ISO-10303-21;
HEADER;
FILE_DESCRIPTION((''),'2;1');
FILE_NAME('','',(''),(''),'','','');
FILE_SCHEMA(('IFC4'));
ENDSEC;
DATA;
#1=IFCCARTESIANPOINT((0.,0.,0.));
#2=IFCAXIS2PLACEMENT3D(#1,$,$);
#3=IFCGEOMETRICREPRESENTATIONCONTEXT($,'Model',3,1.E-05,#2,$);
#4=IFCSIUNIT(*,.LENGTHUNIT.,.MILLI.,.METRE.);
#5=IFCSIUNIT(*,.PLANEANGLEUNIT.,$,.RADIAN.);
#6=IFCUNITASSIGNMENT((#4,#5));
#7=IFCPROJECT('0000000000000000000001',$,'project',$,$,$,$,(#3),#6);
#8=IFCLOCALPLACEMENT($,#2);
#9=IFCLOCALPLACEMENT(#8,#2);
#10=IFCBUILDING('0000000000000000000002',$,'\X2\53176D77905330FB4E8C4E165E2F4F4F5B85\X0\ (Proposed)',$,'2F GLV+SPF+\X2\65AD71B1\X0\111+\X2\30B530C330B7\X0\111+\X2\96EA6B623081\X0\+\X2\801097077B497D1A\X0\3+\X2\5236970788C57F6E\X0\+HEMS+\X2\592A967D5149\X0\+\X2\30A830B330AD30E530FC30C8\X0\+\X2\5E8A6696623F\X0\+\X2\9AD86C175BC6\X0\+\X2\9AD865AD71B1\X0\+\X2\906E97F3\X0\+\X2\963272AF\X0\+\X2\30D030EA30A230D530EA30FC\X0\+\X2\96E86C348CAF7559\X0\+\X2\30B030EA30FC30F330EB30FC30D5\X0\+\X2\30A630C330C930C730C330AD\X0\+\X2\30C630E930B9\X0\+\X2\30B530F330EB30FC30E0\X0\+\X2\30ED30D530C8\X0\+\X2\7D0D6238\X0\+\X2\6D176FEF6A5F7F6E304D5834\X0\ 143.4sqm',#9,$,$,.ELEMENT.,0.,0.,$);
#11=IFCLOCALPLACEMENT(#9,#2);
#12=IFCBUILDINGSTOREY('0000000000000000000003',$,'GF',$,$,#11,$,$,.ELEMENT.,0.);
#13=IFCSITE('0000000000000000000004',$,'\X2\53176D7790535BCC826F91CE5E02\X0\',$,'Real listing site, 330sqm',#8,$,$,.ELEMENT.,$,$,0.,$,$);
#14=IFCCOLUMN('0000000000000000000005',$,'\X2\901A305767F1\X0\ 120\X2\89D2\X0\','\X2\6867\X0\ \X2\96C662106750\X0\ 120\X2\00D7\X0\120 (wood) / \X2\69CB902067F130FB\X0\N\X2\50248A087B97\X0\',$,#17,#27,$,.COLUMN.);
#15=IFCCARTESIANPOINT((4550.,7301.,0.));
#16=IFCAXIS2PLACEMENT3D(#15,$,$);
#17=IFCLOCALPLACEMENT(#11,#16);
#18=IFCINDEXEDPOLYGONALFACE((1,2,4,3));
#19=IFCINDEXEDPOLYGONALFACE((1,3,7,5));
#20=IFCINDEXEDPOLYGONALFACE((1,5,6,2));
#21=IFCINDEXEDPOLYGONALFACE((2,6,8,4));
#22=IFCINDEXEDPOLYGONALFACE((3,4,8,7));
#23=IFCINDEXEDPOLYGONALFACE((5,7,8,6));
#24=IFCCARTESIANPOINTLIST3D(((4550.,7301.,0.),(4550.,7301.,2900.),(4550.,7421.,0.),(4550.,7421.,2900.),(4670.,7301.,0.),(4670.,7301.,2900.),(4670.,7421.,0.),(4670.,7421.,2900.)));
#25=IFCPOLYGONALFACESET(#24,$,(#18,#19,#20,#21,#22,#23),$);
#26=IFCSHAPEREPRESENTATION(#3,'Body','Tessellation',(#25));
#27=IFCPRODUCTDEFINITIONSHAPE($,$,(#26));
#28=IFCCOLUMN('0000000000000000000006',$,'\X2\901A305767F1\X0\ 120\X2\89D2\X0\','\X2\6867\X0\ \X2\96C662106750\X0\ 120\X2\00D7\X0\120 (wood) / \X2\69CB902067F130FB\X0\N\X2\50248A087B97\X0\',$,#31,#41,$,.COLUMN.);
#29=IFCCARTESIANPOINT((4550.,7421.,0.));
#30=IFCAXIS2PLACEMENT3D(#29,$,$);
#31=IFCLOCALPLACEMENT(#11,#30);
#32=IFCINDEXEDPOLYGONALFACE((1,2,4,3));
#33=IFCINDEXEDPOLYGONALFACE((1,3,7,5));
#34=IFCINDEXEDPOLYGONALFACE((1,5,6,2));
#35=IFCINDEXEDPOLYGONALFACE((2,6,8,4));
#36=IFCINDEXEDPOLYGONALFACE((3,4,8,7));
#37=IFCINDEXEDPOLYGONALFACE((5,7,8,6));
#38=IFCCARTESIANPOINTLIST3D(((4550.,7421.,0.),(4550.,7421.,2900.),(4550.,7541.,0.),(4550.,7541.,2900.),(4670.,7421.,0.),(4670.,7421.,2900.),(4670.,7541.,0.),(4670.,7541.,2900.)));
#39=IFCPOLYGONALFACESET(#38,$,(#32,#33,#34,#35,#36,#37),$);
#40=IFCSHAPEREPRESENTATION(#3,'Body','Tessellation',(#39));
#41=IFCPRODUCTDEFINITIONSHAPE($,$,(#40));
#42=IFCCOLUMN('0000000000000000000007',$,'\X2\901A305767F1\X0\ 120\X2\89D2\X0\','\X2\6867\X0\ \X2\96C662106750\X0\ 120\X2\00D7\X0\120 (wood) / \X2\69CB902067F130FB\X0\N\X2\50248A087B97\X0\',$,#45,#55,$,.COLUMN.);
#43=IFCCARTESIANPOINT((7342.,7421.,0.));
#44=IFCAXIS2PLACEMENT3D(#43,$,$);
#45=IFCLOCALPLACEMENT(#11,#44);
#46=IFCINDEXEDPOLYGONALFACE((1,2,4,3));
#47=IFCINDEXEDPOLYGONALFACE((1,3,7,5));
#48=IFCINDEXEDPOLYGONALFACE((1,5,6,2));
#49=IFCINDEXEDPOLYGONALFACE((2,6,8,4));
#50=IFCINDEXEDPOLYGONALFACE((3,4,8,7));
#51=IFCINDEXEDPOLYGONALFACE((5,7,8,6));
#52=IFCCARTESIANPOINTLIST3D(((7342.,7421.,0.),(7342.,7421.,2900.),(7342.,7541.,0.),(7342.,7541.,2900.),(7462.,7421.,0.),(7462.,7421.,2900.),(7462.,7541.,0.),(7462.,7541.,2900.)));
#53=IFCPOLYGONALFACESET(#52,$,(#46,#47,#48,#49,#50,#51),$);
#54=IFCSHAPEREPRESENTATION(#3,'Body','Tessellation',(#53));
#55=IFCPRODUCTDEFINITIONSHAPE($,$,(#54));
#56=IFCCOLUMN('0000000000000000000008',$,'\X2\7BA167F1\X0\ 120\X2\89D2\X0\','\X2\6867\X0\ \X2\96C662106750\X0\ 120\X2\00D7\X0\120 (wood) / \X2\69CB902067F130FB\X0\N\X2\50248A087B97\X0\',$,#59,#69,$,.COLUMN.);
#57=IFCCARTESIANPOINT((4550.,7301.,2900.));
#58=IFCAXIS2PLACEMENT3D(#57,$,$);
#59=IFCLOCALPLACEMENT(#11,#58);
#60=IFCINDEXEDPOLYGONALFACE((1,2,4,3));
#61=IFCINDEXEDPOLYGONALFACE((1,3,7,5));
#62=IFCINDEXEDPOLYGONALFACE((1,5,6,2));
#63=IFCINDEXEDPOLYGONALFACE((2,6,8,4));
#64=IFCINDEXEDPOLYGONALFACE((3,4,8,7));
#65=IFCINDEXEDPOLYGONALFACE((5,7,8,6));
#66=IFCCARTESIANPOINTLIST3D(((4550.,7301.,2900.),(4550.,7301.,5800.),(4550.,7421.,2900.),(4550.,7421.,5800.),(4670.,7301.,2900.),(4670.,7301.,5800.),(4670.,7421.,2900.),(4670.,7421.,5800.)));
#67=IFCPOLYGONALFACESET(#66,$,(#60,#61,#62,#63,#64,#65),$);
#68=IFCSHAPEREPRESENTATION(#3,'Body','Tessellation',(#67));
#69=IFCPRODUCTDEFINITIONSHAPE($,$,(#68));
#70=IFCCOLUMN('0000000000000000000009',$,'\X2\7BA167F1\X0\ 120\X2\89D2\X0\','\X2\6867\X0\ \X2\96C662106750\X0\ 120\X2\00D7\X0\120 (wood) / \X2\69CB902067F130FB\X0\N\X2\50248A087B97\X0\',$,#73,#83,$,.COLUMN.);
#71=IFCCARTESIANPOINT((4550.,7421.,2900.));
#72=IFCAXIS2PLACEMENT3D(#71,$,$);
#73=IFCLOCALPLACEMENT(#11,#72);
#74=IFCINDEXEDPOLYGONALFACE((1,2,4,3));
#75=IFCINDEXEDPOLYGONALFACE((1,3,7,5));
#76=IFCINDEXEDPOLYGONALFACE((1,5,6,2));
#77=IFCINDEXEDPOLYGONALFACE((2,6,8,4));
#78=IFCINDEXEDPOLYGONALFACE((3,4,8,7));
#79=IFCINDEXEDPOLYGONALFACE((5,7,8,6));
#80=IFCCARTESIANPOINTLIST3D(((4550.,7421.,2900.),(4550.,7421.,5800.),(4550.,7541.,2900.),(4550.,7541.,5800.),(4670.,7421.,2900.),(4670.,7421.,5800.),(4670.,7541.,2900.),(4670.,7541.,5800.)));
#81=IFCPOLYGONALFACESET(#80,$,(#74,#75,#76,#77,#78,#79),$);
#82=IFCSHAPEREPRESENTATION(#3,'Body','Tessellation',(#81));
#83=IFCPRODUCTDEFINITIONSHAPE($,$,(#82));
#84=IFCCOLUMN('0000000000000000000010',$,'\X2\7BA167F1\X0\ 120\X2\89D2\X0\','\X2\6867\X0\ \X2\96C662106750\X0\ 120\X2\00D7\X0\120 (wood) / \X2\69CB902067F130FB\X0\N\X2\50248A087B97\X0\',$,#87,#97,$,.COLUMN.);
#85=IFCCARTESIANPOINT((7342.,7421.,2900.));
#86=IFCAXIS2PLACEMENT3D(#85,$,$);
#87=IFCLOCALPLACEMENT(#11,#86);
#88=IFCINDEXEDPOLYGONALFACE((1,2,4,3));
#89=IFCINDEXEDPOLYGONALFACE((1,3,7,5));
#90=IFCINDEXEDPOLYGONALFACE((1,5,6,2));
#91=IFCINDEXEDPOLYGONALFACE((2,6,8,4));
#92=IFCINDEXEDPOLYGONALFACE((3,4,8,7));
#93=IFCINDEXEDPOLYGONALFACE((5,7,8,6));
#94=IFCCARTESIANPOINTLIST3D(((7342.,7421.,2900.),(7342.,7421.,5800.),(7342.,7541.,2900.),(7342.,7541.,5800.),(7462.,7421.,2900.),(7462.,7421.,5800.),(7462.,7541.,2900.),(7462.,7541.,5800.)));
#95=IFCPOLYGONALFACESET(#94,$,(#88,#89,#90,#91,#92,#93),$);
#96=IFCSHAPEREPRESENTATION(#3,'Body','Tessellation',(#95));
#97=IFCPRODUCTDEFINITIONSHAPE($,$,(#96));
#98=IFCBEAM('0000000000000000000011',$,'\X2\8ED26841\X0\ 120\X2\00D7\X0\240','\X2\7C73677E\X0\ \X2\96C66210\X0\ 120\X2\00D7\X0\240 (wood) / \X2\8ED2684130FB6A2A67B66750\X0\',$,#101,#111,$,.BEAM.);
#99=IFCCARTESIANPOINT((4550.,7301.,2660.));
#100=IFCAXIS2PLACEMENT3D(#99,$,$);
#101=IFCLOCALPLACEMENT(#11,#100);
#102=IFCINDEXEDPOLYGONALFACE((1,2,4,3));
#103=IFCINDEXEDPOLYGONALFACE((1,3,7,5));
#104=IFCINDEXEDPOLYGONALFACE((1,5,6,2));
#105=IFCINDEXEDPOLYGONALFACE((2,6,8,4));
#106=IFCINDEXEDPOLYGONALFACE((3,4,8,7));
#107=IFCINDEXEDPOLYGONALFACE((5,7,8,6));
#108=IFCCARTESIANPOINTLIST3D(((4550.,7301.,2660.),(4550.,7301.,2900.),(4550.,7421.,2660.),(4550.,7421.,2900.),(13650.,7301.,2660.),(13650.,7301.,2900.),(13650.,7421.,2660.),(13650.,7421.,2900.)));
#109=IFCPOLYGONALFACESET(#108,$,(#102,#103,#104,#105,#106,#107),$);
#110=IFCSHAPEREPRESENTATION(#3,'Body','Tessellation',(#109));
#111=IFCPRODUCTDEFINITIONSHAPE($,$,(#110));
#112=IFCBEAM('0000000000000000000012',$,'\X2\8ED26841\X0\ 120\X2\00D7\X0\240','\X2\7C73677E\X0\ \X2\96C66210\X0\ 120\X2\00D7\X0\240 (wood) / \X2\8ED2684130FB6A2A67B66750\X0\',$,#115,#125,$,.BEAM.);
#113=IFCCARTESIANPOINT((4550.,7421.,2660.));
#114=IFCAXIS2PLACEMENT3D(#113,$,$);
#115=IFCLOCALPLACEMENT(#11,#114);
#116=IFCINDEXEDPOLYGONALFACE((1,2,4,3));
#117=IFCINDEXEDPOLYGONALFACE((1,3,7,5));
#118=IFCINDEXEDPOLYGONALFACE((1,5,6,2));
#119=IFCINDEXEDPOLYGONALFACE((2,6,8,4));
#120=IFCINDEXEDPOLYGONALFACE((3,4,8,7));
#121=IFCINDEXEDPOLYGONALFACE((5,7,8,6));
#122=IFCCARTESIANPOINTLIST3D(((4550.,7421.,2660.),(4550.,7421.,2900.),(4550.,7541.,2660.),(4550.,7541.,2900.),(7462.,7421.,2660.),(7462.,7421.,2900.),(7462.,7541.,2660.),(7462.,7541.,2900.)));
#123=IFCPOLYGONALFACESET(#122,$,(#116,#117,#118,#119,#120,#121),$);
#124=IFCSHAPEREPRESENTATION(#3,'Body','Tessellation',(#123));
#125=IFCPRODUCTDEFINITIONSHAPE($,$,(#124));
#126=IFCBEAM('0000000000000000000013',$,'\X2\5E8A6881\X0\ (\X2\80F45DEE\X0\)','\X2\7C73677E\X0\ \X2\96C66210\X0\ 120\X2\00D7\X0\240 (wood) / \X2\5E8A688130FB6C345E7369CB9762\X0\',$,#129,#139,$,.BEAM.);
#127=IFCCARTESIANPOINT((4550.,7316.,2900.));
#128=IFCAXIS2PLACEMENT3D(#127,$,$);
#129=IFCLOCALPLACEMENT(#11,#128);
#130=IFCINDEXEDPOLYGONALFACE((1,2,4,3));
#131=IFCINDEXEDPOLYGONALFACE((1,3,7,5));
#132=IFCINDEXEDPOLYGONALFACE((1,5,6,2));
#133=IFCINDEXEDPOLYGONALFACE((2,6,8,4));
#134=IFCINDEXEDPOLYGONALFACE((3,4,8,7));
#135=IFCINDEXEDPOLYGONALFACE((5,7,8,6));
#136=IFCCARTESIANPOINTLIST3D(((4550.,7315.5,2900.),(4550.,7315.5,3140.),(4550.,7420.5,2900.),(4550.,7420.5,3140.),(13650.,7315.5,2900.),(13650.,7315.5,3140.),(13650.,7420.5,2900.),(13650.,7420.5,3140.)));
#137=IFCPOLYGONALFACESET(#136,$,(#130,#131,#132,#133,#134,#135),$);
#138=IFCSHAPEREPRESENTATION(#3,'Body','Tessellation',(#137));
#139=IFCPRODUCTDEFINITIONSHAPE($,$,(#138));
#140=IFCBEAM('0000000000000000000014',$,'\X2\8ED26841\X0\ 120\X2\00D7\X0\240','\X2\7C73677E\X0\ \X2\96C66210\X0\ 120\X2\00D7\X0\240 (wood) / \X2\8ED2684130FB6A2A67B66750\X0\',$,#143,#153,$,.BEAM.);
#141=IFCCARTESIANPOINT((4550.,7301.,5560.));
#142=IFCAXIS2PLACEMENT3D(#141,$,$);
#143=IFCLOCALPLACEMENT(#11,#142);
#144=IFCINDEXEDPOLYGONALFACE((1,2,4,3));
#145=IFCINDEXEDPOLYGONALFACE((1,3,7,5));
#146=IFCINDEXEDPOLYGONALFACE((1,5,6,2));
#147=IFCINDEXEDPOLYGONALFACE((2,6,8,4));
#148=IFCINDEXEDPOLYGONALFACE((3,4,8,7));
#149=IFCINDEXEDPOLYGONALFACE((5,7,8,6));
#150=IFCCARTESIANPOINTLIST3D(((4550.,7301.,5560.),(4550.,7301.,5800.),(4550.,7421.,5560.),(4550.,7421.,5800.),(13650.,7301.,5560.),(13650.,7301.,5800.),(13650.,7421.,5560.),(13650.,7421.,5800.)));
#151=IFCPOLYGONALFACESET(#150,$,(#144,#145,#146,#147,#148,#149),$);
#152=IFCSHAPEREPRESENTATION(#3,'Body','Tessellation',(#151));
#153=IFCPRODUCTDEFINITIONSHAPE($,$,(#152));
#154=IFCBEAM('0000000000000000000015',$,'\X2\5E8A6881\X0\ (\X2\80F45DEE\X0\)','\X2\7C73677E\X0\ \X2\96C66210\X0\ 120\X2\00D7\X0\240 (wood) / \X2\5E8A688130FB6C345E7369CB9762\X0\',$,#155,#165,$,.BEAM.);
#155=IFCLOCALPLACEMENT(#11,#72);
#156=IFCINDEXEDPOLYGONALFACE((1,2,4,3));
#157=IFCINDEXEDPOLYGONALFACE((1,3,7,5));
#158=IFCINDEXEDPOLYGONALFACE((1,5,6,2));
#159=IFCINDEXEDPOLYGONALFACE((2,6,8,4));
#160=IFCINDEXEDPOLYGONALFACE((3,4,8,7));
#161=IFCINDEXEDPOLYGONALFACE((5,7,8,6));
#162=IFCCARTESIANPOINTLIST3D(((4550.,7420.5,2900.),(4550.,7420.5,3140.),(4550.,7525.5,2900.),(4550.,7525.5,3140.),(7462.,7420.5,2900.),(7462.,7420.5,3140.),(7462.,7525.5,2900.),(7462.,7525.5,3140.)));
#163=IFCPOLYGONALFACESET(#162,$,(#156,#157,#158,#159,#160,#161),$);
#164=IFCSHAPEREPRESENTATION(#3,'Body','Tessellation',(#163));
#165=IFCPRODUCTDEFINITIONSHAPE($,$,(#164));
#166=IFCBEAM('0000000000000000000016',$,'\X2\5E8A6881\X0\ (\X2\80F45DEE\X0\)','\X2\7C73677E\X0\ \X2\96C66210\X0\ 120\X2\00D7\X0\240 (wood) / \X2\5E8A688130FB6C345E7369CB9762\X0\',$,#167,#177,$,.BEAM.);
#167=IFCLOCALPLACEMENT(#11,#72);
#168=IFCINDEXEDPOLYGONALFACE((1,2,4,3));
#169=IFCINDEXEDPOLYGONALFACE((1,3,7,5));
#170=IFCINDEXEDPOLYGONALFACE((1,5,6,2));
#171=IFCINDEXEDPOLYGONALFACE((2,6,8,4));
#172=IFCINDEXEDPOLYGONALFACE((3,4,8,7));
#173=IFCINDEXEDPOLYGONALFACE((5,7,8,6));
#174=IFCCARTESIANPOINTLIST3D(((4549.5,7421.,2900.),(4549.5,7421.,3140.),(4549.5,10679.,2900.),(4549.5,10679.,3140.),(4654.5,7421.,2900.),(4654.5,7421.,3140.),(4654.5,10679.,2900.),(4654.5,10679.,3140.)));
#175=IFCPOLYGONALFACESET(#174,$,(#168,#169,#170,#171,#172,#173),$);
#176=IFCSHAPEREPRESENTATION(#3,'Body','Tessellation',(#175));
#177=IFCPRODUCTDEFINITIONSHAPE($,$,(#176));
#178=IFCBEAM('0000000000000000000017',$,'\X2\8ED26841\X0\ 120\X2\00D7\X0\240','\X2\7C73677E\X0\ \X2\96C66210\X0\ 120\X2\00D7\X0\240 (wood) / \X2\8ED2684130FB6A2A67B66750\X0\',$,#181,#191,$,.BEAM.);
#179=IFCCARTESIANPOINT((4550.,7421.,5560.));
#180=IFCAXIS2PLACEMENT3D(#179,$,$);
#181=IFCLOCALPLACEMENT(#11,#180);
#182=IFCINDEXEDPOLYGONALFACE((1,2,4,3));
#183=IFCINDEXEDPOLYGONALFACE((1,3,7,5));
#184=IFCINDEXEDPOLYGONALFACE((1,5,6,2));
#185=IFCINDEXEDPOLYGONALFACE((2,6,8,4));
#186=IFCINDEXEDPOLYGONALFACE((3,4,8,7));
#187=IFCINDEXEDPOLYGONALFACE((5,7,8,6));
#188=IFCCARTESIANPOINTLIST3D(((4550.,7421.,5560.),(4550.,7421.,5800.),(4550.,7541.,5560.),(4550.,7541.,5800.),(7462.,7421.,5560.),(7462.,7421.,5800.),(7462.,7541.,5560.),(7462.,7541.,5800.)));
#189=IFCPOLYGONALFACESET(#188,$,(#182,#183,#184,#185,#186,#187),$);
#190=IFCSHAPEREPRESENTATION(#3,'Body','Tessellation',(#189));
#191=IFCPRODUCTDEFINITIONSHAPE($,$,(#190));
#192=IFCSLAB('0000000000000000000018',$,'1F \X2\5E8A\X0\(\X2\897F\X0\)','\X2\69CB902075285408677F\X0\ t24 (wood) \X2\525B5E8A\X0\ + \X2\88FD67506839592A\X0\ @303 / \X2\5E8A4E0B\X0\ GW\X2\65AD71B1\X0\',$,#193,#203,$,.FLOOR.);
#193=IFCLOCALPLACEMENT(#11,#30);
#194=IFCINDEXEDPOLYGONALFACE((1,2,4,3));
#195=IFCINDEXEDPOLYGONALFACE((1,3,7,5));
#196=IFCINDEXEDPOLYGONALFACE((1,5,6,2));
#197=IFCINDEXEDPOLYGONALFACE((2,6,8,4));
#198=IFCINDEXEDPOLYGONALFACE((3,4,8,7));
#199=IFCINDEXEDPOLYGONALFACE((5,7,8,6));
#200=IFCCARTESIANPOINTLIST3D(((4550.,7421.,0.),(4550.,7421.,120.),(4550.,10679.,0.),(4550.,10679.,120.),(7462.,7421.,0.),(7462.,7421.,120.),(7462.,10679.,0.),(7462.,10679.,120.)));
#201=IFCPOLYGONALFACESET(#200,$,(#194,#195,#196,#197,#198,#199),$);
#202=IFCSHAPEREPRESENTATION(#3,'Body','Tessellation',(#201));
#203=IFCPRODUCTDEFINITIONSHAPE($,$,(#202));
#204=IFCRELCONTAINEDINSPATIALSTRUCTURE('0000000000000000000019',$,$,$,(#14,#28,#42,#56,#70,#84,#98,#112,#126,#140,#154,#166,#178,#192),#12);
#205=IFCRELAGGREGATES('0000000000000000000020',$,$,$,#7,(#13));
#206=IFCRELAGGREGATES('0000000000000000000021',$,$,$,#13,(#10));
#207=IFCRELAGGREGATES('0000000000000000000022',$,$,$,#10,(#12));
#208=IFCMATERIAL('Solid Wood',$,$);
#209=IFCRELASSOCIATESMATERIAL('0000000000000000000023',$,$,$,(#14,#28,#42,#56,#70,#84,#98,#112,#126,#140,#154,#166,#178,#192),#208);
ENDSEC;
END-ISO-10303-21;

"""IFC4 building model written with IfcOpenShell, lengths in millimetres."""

from ifc_helpers import new_model, si_unit, frame, frame_2d, origin, place, context, project, spatial, rectangle, extrude, material, element, save


model = new_model("IFC4")

# Units and contexts
model_context = context("Model", 3, precision=1e-05, world=origin())
ifc_project = project(units=[si_unit("LENGTHUNIT", "METRE", prefix="MILLI"), si_unit("PLANEANGLEUNIT", "RADIAN")], contexts=[model_context])

# Site, building, storey
site_placement = place(None, origin())
site = spatial("IfcSite", under=ifc_project, at=site_placement, Name="北海道富良野市", ObjectType="Real listing site, 330sqm", CompositionType="ELEMENT", RefElevation=0.0)
building_placement = place(site_placement, origin())
building = spatial("IfcBuilding", under=site, at=building_placement, Name="北海道・二世帯住宅 (Proposed)", ObjectType="2F GLV+SPF+断熱111+サッシ111+雪止め+耐震等級3+制震装置+HEMS+太陽光+エコキュート+床暖房+高気密+高断熱+遮音+防犯+バリアフリー+雨水貯留+グリーンルーフ+ウッドデッキ+テラス+サンルーム+ロフト+納戸+洗濯機置き場 143.4sqm", CompositionType="ELEMENT", ElevationOfRefHeight=0.0, ElevationOfTerrain=0.0)
storey_placement = place(building_placement, origin())
storey = spatial("IfcBuildingStorey", under=building, at=storey_placement, Name="GF", CompositionType="ELEMENT", Elevation=0.0)

# Columns
ifc_material_1 = material(Name="Solid Wood")
column_1_placement = place(storey_placement, frame((4550.0, 7301.0, 0.0)))
element("IfcColumn", 1, at=column_1_placement, inside=storey, material=ifc_material_1, Name="通し柱 120角", Description="桧 集成材 120×120 (wood) / 構造柱・N値計算", PredefinedType="COLUMN", context=model_context, shape_type="SweptSolid", body=[
    extrude(rectangle(XDim=120.0, YDim=120.0, at=frame_2d((60.0, 60.0))), frame((4550.0, 7301.0, 0.0)), (0.0, 0.0, 1.0), 2900.0),
])
column_2_placement = place(storey_placement, frame((4550.0, 7421.0, 0.0)))
element("IfcColumn", 2, at=column_2_placement, inside=storey, material=ifc_material_1, Name="通し柱 120角", Description="桧 集成材 120×120 (wood) / 構造柱・N値計算", PredefinedType="COLUMN", context=model_context, shape_type="SweptSolid", body=[
    extrude(rectangle(XDim=120.0, YDim=120.0, at=frame_2d((60.0, 60.0))), frame((4550.0, 7421.0, 0.0)), (0.0, 0.0, 1.0), 2900.0),
])
column_3_placement = place(storey_placement, frame((7342.0, 7421.0, 0.0)))
element("IfcColumn", 3, at=column_3_placement, inside=storey, material=ifc_material_1, Name="通し柱 120角", Description="桧 集成材 120×120 (wood) / 構造柱・N値計算", PredefinedType="COLUMN", context=model_context, shape_type="SweptSolid", body=[
    extrude(rectangle(XDim=120.0, YDim=120.0, at=frame_2d((60.0, 60.0))), frame((7342.0, 7421.0, 0.0)), (0.0, 0.0, 1.0), 2900.0),
])
column_4_placement = place(storey_placement, frame((4550.0, 7301.0, 2900.0)))
element("IfcColumn", 4, at=column_4_placement, inside=storey, material=ifc_material_1, Name="管柱 120角", Description="桧 集成材 120×120 (wood) / 構造柱・N値計算", PredefinedType="COLUMN", context=model_context, shape_type="SweptSolid", body=[
    extrude(rectangle(XDim=120.0, YDim=120.0, at=frame_2d((60.0, 60.0))), frame((4550.0, 7301.0, 2900.0)), (0.0, 0.0, 1.0), 2900.0),
])
column_5_placement = place(storey_placement, frame((4550.0, 7421.0, 2900.0)))
element("IfcColumn", 5, at=column_5_placement, inside=storey, material=ifc_material_1, Name="管柱 120角", Description="桧 集成材 120×120 (wood) / 構造柱・N値計算", PredefinedType="COLUMN", context=model_context, shape_type="SweptSolid", body=[
    extrude(rectangle(XDim=120.0, YDim=120.0, at=frame_2d((60.0, 60.0))), frame((4550.0, 7421.0, 2900.0)), (0.0, 0.0, 1.0), 2900.0),
])
column_6_placement = place(storey_placement, frame((7342.0, 7421.0, 2900.0)))
element("IfcColumn", 6, at=column_6_placement, inside=storey, material=ifc_material_1, Name="管柱 120角", Description="桧 集成材 120×120 (wood) / 構造柱・N値計算", PredefinedType="COLUMN", context=model_context, shape_type="SweptSolid", body=[
    extrude(rectangle(XDim=120.0, YDim=120.0, at=frame_2d((60.0, 60.0))), frame((7342.0, 7421.0, 2900.0)), (0.0, 0.0, 1.0), 2900.0),
])

# Beams
beam_1_placement = place(storey_placement, frame((4550.0, 7301.0, 2660.0)))
element("IfcBeam", 7, at=beam_1_placement, inside=storey, material=ifc_material_1, Name="軒桁 120×240", Description="米松 集成 120×240 (wood) / 軒桁・横架材", PredefinedType="BEAM", context=model_context, shape_type="SweptSolid", body=[
    extrude(rectangle(XDim=9100.0, YDim=120.0, at=frame_2d((4550.0, 60.0))), frame((4550.0, 7301.0, 2660.0)), (0.0, 0.0, 1.0), 240.0),
])
beam_2_placement = place(storey_placement, frame((4550.0, 7421.0, 2660.0)))
element("IfcBeam", 8, at=beam_2_placement, inside=storey, material=ifc_material_1, Name="軒桁 120×240", Description="米松 集成 120×240 (wood) / 軒桁・横架材", PredefinedType="BEAM", context=model_context, shape_type="SweptSolid", body=[
    extrude(rectangle(XDim=2912.0, YDim=120.0, at=frame_2d((1456.0, 60.0))), frame((4550.0, 7421.0, 2660.0)), (0.0, 0.0, 1.0), 240.0),
])
beam_3_placement = place(storey_placement, frame((4550.0, 7316.0, 2900.0)))
element("IfcBeam", 9, at=beam_3_placement, inside=storey, material=ifc_material_1, Name="床梁 (胴差)", Description="米松 集成 120×240 (wood) / 床梁・水平構面", PredefinedType="BEAM", context=model_context, shape_type="SweptSolid", body=[
    extrude(rectangle(XDim=9100.0, YDim=105.0, at=frame_2d((4550.0, 52.0))), frame((4550.0, 7316.0, 2900.0)), (0.0, 0.0, 1.0), 240.0),
])
beam_4_placement = place(storey_placement, frame((4550.0, 7301.0, 5560.0)))
element("IfcBeam", 10, at=beam_4_placement, inside=storey, material=ifc_material_1, Name="軒桁 120×240", Description="米松 集成 120×240 (wood) / 軒桁・横架材", PredefinedType="BEAM", context=model_context, shape_type="SweptSolid", body=[
    extrude(rectangle(XDim=9100.0, YDim=120.0, at=frame_2d((4550.0, 60.0))), frame((4550.0, 7301.0, 5560.0)), (0.0, 0.0, 1.0), 240.0),
])
beam_5_placement = place(storey_placement, frame((4550.0, 7421.0, 2900.0)))
element("IfcBeam", 11, at=beam_5_placement, inside=storey, material=ifc_material_1, Name="床梁 (胴差)", Description="米松 集成 120×240 (wood) / 床梁・水平構面", PredefinedType="BEAM", context=model_context, shape_type="SweptSolid", body=[
    extrude(rectangle(XDim=2912.0, YDim=105.0, at=frame_2d((1456.0, 52.0))), frame((4550.0, 7421.0, 2900.0)), (0.0, 0.0, 1.0), 240.0),
])
beam_6_placement = place(storey_placement, frame((4550.0, 7421.0, 2900.0)))
element("IfcBeam", 12, at=beam_6_placement, inside=storey, material=ifc_material_1, Name="床梁 (胴差)", Description="米松 集成 120×240 (wood) / 床梁・水平構面", PredefinedType="BEAM", context=model_context, shape_type="SweptSolid", body=[
    extrude(rectangle(XDim=105.0, YDim=3258.0, at=frame_2d((52.0, 1629.0))), frame((4550.0, 7421.0, 2900.0)), (0.0, 0.0, 1.0), 240.0),
])
beam_7_placement = place(storey_placement, frame((4550.0, 7421.0, 5560.0)))
element("IfcBeam", 13, at=beam_7_placement, inside=storey, material=ifc_material_1, Name="軒桁 120×240", Description="米松 集成 120×240 (wood) / 軒桁・横架材", PredefinedType="BEAM", context=model_context, shape_type="SweptSolid", body=[
    extrude(rectangle(XDim=2912.0, YDim=120.0, at=frame_2d((1456.0, 60.0))), frame((4550.0, 7421.0, 5560.0)), (0.0, 0.0, 1.0), 240.0),
])

# Slab
slab_1_placement = place(storey_placement, frame((4550.0, 7421.0, 0.0)))
element("IfcSlab", 14, at=slab_1_placement, inside=storey, material=ifc_material_1, Name="1F 床(西)", Description="構造用合板 t24 (wood) 剛床 + 製材根太 @303 / 床下 GW断熱", PredefinedType="FLOOR", context=model_context, shape_type="SweptSolid", body=[
    extrude(rectangle(XDim=2912.0, YDim=3258.0, at=frame_2d((1456.0, 1629.0))), frame((4550.0, 7421.0, 0.0)), (0.0, 0.0, 1.0), 120.0),
])

save(model, "model.ifc")
